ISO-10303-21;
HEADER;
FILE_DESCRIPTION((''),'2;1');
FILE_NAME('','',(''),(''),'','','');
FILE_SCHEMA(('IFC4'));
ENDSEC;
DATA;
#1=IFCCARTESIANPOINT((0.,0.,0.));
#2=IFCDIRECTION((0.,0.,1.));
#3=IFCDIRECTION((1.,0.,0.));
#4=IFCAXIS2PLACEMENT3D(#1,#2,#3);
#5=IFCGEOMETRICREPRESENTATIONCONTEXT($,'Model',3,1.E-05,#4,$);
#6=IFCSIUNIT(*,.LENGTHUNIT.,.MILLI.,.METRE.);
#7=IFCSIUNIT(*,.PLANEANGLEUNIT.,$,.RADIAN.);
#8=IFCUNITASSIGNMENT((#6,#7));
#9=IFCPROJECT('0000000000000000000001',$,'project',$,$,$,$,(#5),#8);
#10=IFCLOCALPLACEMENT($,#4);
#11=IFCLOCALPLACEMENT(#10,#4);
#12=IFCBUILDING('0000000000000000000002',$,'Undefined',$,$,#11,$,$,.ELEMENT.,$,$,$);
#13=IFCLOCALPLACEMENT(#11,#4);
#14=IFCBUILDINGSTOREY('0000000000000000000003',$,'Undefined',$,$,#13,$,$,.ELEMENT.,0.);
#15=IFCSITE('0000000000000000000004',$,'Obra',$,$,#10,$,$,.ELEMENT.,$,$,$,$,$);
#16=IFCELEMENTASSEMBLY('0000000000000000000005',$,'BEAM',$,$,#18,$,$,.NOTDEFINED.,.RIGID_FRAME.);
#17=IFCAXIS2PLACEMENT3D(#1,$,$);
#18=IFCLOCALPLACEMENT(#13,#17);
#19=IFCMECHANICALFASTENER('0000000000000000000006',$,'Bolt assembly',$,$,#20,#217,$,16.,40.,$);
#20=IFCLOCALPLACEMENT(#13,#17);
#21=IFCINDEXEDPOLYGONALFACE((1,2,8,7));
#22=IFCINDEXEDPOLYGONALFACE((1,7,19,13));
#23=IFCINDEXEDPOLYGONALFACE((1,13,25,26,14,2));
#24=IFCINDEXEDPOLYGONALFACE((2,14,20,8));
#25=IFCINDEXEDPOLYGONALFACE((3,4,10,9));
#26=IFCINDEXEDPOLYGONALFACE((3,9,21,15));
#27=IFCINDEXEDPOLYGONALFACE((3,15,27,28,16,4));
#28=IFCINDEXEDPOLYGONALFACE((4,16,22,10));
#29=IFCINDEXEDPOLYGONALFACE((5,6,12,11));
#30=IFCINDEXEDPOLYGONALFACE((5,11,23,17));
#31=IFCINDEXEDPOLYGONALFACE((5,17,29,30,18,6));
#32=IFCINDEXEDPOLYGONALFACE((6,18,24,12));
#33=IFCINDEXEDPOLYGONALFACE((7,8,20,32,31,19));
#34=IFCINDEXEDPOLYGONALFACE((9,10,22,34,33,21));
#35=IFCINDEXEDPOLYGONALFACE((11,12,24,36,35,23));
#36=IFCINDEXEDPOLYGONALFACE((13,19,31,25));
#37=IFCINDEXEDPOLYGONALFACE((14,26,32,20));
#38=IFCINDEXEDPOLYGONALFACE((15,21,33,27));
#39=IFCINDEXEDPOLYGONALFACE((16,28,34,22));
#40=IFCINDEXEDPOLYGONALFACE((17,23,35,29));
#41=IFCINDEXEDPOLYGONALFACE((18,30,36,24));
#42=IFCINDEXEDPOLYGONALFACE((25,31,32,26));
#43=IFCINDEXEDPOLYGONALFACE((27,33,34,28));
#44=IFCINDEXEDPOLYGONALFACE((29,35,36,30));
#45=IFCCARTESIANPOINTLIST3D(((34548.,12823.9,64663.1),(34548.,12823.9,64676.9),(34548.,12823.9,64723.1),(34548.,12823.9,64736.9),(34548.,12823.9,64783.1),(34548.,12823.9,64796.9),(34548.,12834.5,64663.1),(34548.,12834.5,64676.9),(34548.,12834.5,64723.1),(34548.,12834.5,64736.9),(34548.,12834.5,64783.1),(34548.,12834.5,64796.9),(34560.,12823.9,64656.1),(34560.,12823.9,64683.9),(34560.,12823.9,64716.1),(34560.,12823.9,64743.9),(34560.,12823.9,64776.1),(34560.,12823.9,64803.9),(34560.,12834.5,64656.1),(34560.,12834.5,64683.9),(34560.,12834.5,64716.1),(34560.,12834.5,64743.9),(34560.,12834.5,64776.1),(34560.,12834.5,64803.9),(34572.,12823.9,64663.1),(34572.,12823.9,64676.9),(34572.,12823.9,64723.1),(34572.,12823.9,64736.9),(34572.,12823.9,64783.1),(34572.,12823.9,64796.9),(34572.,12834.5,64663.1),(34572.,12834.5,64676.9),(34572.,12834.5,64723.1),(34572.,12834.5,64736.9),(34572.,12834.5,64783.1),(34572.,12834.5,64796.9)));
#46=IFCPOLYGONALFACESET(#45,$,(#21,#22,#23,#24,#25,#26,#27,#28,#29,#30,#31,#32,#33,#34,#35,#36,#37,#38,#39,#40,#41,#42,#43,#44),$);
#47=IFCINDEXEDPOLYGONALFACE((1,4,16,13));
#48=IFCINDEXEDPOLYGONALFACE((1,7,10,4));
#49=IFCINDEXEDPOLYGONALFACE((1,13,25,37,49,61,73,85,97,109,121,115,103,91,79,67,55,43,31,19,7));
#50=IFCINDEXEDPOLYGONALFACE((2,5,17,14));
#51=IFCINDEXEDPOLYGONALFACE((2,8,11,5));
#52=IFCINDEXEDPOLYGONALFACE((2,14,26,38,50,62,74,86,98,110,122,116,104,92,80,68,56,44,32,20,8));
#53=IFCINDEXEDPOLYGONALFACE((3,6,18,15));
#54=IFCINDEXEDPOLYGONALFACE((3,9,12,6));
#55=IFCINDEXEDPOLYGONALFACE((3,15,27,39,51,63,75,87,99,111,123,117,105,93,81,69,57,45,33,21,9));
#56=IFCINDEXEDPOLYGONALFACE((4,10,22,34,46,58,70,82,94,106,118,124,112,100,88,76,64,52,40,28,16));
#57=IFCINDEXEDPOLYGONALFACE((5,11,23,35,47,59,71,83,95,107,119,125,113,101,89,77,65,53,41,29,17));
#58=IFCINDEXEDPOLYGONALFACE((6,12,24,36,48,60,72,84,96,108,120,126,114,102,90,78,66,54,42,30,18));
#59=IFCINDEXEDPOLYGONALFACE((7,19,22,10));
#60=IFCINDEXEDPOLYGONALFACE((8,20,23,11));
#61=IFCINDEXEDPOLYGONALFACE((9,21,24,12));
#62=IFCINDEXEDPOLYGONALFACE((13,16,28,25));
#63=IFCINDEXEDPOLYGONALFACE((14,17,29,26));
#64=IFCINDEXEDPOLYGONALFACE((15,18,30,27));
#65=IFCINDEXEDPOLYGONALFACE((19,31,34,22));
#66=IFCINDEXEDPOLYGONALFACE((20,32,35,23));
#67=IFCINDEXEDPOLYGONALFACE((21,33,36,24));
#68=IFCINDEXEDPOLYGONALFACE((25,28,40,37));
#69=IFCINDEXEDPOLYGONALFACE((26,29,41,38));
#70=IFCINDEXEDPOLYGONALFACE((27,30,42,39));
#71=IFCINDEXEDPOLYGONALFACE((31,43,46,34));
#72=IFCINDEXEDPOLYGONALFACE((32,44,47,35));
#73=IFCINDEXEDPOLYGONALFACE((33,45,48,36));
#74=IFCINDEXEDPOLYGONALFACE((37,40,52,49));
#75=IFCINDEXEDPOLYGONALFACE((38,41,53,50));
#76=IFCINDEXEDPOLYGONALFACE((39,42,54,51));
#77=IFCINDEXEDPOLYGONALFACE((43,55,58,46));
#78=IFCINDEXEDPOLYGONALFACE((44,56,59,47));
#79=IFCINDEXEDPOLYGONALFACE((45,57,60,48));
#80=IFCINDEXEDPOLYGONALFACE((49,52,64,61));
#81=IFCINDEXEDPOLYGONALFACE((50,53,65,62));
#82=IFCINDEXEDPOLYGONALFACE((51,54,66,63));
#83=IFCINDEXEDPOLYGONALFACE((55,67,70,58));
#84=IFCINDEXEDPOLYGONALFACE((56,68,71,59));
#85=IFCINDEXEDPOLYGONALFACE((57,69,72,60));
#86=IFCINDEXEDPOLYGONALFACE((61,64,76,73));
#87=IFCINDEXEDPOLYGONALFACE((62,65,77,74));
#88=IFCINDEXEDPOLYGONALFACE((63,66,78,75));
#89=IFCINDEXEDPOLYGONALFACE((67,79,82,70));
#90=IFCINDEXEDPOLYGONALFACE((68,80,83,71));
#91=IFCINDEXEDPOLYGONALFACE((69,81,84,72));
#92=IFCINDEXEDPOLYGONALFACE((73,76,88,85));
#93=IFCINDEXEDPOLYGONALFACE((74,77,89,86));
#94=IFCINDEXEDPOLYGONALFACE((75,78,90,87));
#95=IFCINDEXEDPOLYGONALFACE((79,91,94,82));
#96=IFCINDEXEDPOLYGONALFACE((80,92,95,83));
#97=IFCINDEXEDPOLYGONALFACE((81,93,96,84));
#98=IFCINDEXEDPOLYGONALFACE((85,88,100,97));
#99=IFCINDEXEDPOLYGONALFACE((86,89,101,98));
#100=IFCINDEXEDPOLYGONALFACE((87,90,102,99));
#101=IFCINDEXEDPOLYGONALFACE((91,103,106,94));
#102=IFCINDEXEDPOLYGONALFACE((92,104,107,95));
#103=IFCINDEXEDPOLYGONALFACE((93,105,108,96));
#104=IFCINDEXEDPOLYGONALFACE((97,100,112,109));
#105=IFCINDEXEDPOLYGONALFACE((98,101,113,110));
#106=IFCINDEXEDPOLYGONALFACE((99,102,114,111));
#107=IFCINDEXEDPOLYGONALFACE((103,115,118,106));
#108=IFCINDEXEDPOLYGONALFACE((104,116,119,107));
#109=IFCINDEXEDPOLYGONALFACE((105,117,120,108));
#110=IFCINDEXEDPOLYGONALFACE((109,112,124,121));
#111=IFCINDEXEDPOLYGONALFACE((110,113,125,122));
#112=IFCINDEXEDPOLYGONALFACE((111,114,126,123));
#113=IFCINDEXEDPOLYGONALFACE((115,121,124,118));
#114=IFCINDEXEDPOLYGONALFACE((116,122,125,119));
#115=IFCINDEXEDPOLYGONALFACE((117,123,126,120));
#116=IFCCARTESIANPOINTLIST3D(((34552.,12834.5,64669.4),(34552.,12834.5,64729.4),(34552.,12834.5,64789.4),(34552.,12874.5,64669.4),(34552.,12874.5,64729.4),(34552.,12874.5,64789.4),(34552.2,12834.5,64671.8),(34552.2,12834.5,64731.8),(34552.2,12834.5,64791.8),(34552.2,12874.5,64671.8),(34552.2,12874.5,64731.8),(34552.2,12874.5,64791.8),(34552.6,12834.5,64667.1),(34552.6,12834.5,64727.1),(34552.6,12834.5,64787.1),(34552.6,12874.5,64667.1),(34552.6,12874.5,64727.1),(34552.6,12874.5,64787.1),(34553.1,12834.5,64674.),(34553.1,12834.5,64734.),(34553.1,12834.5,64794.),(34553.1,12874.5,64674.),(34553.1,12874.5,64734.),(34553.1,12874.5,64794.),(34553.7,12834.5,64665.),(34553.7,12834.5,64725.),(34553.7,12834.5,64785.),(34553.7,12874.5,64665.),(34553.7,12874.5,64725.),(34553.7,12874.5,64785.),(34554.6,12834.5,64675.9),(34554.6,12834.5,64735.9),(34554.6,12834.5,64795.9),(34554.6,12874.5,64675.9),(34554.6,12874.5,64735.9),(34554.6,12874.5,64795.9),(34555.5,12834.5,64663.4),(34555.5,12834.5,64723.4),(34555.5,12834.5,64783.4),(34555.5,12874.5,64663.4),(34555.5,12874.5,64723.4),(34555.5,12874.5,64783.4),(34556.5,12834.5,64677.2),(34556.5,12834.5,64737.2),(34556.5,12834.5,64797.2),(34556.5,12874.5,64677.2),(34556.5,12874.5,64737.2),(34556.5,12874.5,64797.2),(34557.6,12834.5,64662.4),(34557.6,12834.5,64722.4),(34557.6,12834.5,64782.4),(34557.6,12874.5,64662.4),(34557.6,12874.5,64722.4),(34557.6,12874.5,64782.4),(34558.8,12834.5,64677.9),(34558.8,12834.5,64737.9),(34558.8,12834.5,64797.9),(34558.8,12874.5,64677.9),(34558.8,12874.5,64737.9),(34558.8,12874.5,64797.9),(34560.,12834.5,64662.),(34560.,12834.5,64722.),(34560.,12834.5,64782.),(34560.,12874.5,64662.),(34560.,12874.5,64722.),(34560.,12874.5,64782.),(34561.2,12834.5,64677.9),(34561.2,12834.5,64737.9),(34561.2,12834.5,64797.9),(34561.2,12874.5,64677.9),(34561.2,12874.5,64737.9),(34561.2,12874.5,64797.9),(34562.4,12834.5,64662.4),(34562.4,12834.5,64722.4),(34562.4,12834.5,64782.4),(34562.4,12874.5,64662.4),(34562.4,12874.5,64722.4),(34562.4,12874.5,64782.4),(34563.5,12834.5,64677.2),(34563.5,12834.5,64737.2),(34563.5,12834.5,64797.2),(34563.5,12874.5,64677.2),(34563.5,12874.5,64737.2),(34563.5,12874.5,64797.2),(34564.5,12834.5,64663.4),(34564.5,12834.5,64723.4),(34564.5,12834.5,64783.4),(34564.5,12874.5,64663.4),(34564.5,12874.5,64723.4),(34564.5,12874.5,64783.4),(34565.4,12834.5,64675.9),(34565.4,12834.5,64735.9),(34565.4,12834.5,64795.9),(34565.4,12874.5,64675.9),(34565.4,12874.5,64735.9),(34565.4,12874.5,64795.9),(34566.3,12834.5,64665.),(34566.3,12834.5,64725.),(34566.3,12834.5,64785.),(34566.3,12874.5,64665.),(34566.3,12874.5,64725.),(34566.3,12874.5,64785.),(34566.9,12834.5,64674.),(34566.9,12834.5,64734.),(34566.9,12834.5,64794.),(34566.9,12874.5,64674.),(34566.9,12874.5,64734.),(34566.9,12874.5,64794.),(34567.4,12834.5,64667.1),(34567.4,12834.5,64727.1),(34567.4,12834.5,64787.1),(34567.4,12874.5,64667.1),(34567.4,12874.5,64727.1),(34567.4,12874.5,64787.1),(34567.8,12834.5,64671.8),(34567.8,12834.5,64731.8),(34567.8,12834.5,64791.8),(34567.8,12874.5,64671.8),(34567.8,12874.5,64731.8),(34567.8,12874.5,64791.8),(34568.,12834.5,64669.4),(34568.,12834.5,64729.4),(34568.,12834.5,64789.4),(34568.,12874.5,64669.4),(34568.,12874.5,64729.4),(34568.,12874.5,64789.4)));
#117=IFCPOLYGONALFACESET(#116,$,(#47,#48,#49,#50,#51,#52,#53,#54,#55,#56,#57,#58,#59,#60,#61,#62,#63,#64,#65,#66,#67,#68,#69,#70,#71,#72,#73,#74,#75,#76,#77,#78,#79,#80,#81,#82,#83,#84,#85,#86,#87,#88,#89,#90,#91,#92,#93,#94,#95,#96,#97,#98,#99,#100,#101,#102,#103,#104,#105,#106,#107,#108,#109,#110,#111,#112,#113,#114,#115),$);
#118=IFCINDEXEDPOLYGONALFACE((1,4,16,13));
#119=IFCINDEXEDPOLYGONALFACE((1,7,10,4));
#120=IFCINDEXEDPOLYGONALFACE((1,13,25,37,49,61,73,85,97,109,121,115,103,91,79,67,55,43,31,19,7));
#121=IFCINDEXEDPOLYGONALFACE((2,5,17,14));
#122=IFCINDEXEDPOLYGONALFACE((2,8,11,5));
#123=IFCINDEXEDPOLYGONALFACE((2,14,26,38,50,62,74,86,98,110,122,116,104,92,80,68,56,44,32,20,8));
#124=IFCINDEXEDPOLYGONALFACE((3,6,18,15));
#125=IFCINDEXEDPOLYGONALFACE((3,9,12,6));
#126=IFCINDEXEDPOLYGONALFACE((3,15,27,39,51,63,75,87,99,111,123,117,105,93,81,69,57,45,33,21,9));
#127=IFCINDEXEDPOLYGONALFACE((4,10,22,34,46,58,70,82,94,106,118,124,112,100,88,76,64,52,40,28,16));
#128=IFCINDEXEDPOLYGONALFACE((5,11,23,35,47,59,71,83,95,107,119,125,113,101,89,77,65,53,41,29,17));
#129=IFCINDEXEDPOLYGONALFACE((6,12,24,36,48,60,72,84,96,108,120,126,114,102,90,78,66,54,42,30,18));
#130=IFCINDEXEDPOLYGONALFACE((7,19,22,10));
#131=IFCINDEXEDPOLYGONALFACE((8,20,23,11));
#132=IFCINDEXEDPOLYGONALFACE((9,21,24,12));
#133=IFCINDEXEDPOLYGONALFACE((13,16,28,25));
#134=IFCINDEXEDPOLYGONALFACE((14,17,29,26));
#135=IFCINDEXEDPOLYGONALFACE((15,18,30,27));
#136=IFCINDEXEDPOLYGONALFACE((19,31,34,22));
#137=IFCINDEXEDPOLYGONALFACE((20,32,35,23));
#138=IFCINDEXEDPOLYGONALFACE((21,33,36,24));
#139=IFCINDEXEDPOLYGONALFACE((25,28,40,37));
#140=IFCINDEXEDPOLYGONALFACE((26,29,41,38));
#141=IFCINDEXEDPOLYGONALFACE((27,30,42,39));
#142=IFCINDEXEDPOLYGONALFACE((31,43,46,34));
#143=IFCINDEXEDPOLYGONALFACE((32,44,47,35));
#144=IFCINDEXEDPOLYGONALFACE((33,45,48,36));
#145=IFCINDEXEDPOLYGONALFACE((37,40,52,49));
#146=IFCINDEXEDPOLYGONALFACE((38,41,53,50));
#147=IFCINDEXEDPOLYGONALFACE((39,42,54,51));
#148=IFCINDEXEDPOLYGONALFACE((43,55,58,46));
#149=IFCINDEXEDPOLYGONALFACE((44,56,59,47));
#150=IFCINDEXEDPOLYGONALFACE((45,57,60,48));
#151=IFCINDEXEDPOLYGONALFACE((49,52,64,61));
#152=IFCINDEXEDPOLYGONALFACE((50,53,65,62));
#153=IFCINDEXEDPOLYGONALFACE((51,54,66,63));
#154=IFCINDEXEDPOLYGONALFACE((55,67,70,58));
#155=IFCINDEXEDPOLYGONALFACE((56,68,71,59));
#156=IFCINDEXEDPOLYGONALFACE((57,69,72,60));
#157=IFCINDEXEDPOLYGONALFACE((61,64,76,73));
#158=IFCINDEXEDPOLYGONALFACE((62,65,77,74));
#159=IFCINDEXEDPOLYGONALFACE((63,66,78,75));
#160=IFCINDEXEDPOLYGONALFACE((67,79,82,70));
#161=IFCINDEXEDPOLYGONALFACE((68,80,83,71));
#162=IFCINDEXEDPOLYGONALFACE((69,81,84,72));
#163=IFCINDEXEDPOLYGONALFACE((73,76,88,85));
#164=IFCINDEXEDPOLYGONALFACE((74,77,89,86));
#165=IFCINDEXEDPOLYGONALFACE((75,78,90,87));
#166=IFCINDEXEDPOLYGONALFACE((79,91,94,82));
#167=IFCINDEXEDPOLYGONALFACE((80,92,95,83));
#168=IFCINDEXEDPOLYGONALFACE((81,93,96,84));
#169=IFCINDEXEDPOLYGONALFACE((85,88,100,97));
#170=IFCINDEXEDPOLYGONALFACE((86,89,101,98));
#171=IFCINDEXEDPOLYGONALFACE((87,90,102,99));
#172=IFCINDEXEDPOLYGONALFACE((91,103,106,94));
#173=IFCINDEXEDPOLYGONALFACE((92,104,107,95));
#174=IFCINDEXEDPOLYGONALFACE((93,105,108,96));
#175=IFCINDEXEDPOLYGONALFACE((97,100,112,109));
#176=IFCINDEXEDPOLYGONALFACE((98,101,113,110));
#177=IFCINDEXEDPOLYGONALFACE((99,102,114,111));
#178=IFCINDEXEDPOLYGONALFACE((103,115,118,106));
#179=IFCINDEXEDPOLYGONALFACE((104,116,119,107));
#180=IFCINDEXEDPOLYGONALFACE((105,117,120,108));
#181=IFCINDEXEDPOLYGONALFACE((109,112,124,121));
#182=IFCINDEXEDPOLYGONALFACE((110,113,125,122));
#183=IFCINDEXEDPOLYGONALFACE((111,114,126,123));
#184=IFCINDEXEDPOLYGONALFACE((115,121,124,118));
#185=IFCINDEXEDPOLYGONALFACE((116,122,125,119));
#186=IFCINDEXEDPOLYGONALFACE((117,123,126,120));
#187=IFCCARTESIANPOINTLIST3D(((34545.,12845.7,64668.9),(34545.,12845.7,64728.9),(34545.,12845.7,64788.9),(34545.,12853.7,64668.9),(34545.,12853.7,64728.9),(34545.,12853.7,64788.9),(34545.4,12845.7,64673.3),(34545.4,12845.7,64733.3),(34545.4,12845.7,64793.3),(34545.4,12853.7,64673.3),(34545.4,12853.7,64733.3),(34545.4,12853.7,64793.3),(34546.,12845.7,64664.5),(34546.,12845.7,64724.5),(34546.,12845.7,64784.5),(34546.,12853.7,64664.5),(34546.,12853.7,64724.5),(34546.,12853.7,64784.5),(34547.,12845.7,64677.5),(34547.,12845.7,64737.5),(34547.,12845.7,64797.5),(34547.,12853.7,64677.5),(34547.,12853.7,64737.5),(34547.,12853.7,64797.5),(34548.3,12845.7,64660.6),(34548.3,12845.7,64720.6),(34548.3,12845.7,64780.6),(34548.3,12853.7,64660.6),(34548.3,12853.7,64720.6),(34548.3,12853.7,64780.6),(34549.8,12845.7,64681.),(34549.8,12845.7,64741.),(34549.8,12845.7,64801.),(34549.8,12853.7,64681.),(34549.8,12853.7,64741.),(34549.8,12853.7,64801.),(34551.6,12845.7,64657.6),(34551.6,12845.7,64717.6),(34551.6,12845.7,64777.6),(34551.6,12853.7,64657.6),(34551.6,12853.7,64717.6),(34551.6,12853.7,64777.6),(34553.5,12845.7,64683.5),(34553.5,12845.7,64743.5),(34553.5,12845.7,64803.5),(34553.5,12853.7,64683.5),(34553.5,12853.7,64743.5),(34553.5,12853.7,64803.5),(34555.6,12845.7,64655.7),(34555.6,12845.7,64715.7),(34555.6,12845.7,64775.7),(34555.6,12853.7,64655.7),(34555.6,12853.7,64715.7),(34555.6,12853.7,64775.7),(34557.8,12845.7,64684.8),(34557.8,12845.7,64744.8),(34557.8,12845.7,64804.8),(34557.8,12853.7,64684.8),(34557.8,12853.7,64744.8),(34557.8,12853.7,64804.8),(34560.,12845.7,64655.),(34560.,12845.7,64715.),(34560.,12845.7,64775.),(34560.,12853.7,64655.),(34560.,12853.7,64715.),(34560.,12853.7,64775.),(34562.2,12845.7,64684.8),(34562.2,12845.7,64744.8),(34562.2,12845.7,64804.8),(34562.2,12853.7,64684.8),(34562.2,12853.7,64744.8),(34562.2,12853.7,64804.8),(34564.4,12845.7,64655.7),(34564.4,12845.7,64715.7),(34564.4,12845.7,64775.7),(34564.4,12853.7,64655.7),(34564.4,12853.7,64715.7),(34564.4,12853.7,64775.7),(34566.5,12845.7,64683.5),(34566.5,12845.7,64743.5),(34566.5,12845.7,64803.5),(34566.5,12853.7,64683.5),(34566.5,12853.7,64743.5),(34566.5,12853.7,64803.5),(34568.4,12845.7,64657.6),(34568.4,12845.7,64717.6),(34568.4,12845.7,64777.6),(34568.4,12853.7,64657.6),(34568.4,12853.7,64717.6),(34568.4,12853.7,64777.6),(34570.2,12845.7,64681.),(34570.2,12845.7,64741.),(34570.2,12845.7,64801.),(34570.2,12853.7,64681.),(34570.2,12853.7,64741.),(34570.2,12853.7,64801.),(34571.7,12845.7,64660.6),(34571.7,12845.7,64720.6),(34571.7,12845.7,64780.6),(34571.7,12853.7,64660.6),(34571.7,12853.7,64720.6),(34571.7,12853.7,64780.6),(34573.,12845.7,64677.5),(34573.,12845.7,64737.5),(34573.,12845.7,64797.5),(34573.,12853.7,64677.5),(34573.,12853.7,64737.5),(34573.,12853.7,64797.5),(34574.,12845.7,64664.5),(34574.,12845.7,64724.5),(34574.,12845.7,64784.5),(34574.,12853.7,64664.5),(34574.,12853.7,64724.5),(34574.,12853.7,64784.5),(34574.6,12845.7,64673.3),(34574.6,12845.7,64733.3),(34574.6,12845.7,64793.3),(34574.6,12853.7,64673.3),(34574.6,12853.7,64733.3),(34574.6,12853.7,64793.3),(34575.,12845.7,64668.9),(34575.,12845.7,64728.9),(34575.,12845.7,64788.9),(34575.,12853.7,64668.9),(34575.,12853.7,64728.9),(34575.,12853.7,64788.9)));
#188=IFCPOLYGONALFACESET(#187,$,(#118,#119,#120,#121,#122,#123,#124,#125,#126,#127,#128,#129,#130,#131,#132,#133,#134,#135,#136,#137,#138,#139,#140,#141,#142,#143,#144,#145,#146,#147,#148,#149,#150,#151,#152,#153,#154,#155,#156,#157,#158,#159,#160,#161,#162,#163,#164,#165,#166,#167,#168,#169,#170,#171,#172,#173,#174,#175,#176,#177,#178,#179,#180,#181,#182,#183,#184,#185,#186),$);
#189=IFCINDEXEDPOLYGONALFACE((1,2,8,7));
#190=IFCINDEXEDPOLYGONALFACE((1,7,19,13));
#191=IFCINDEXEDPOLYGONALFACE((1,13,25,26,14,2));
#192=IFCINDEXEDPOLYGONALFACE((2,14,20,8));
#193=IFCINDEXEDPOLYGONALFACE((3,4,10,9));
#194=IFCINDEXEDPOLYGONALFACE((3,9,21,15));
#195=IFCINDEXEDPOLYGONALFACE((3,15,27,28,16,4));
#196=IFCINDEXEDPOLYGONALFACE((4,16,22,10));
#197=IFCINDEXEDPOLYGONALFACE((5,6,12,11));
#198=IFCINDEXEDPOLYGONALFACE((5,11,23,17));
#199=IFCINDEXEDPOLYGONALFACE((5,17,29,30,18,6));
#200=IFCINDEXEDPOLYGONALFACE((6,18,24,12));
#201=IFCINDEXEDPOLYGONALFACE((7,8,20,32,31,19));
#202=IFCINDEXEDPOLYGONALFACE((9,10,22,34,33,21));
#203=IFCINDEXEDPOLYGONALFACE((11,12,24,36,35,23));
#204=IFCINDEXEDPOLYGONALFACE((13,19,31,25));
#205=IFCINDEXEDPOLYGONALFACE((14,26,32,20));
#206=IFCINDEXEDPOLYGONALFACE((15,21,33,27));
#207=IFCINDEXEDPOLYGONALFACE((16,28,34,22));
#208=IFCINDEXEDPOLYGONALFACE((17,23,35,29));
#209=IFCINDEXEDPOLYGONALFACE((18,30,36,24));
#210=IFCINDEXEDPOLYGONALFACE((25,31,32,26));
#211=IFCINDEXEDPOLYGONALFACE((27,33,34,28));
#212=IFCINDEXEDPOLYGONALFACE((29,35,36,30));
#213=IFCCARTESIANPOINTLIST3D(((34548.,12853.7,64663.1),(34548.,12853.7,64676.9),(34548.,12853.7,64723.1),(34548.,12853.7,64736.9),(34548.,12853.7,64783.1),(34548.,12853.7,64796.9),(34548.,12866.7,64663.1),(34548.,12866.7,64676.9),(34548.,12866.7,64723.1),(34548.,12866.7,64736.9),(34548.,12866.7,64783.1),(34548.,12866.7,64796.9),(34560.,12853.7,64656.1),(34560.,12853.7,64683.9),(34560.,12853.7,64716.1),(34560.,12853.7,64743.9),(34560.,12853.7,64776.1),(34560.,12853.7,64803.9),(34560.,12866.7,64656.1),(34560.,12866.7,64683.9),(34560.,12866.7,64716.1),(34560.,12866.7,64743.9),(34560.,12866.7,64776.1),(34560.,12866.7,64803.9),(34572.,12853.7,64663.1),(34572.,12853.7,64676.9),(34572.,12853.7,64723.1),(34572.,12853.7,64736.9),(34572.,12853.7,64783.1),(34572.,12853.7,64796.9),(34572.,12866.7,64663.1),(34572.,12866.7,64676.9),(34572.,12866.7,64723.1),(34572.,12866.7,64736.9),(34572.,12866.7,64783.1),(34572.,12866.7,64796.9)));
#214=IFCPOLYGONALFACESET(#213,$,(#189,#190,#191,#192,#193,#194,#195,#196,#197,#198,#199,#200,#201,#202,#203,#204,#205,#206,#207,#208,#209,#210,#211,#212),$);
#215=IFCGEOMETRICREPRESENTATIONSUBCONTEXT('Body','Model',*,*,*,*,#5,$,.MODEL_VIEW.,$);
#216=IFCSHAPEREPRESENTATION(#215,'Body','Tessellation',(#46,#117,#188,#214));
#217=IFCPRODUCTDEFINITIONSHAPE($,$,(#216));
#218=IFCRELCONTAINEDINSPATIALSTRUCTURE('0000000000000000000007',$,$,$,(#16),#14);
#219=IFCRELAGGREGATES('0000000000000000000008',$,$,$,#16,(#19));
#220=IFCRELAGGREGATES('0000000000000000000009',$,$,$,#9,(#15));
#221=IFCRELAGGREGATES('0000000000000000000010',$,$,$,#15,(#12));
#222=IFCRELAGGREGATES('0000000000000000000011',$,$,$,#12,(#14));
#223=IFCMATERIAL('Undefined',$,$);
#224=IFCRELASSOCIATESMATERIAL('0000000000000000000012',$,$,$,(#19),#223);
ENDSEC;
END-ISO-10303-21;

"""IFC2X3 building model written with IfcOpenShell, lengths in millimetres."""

from ifc_helpers import new_model, si_unit, frame, origin_with_axes, origin_2d_with_axis, place, context, subcontext, project, spatial, polyline, circle, outline, extrude, source, transform, mapped, material, element, aggregate, save


model = new_model("IFC2X3")

# Units and contexts
model_context = context("Model", 3, precision=1e-05, world=origin_with_axes())
body_context = subcontext(model_context, "Body", "Model", "MODEL_VIEW")
ifc_project = project(units=[si_unit("LENGTHUNIT", "METRE", prefix="MILLI"), si_unit("PLANEANGLEUNIT", "RADIAN")], contexts=[model_context])

# Site, building, storey
site_placement = place(None, origin_with_axes())
site = spatial("IfcSite", under=ifc_project, at=site_placement, Name="Obra", CompositionType="ELEMENT")
building_placement = place(site_placement, origin_with_axes())
building = spatial("IfcBuilding", under=site, at=building_placement, Name="Undefined", CompositionType="ELEMENT")
storey_placement = place(building_placement, origin_with_axes())
storey = spatial("IfcBuildingStorey", under=building, at=storey_placement, Name="Undefined", CompositionType="ELEMENT", Elevation=0.0)

# Shared definitions
ifc_material = material(Name="Undefined")

# Element assembly
assembly_1_placement = place(storey_placement, origin_with_axes())
assembly_1 = element("IfcElementAssembly", 1, at=assembly_1_placement, inside=storey, Name="BEAM", AssemblyPlace="NOTDEFINED", PredefinedType="RIGID_FRAME")

# Mechanical fastener
shared_shape_1 = source(origin_with_axes(), body_context, "Body", "SweptSolid", [
    extrude(outline(polyline([(13.9, 0.0), (6.9, 12.0), (-6.9, 12.0), (-13.9, 0.0), (-6.9, -12.0), (6.9, -12.0), (13.9, 0.0)])), frame((0.0, -19.7, 0.0), z_axis=(0.0, 1.0, 0.0), x_axis=(1.0, 0.0, 0.0)), (0.0, 0.0, 1.0), 10.6),
    extrude(circle(Radius=8.0, at=origin_2d_with_axis()), frame((0.0, -9.1, 0.0), z_axis=(0.0, 1.0, 0.0), x_axis=(1.0, 0.0, 0.0)), (0.0, 0.0, 1.0), 40.0),
    extrude(circle(Radius=15.0, at=origin_2d_with_axis()), frame((0.0, 2.1, 0.0), z_axis=(0.0, 1.0, 0.0), x_axis=(1.0, 0.0, 0.0)), (0.0, 0.0, 1.0), 8.0),
    extrude(outline(polyline([(13.9, 0.0), (6.9, 12.0), (-6.9, 12.0), (-13.9, 0.0), (-6.9, -12.0), (6.9, -12.0), (13.9, 0.0)])), frame((0.0, 10.1, 0.0), z_axis=(0.0, 1.0, 0.0), x_axis=(1.0, 0.0, 0.0)), (0.0, 0.0, 1.0), 13.0),
])
mechanical_fastener_1_placement = place(assembly_1_placement, frame((34510.0, 12843.6, 64850.0), z_axis=(1.0, 0.0, 0.0), x_axis=(0.0, 0.0, -1.0)))
mechanical_fastener_1 = element("IfcMechanicalFastener", 2, at=mechanical_fastener_1_placement, material=ifc_material, Name="Bolt assembly", NominalDiameter=16.0, NominalLength=40.0, context=body_context, shape_type="MappedRepresentation", body=[
    mapped(shared_shape_1, transform((60.0, 0.0, 50.0))),
    mapped(shared_shape_1, transform((120.0, 0.0, 50.0))),
    mapped(shared_shape_1, transform((180.0, 0.0, 50.0))),
])
aggregate(assembly_1, [mechanical_fastener_1])

save(model, "model.ifc")
